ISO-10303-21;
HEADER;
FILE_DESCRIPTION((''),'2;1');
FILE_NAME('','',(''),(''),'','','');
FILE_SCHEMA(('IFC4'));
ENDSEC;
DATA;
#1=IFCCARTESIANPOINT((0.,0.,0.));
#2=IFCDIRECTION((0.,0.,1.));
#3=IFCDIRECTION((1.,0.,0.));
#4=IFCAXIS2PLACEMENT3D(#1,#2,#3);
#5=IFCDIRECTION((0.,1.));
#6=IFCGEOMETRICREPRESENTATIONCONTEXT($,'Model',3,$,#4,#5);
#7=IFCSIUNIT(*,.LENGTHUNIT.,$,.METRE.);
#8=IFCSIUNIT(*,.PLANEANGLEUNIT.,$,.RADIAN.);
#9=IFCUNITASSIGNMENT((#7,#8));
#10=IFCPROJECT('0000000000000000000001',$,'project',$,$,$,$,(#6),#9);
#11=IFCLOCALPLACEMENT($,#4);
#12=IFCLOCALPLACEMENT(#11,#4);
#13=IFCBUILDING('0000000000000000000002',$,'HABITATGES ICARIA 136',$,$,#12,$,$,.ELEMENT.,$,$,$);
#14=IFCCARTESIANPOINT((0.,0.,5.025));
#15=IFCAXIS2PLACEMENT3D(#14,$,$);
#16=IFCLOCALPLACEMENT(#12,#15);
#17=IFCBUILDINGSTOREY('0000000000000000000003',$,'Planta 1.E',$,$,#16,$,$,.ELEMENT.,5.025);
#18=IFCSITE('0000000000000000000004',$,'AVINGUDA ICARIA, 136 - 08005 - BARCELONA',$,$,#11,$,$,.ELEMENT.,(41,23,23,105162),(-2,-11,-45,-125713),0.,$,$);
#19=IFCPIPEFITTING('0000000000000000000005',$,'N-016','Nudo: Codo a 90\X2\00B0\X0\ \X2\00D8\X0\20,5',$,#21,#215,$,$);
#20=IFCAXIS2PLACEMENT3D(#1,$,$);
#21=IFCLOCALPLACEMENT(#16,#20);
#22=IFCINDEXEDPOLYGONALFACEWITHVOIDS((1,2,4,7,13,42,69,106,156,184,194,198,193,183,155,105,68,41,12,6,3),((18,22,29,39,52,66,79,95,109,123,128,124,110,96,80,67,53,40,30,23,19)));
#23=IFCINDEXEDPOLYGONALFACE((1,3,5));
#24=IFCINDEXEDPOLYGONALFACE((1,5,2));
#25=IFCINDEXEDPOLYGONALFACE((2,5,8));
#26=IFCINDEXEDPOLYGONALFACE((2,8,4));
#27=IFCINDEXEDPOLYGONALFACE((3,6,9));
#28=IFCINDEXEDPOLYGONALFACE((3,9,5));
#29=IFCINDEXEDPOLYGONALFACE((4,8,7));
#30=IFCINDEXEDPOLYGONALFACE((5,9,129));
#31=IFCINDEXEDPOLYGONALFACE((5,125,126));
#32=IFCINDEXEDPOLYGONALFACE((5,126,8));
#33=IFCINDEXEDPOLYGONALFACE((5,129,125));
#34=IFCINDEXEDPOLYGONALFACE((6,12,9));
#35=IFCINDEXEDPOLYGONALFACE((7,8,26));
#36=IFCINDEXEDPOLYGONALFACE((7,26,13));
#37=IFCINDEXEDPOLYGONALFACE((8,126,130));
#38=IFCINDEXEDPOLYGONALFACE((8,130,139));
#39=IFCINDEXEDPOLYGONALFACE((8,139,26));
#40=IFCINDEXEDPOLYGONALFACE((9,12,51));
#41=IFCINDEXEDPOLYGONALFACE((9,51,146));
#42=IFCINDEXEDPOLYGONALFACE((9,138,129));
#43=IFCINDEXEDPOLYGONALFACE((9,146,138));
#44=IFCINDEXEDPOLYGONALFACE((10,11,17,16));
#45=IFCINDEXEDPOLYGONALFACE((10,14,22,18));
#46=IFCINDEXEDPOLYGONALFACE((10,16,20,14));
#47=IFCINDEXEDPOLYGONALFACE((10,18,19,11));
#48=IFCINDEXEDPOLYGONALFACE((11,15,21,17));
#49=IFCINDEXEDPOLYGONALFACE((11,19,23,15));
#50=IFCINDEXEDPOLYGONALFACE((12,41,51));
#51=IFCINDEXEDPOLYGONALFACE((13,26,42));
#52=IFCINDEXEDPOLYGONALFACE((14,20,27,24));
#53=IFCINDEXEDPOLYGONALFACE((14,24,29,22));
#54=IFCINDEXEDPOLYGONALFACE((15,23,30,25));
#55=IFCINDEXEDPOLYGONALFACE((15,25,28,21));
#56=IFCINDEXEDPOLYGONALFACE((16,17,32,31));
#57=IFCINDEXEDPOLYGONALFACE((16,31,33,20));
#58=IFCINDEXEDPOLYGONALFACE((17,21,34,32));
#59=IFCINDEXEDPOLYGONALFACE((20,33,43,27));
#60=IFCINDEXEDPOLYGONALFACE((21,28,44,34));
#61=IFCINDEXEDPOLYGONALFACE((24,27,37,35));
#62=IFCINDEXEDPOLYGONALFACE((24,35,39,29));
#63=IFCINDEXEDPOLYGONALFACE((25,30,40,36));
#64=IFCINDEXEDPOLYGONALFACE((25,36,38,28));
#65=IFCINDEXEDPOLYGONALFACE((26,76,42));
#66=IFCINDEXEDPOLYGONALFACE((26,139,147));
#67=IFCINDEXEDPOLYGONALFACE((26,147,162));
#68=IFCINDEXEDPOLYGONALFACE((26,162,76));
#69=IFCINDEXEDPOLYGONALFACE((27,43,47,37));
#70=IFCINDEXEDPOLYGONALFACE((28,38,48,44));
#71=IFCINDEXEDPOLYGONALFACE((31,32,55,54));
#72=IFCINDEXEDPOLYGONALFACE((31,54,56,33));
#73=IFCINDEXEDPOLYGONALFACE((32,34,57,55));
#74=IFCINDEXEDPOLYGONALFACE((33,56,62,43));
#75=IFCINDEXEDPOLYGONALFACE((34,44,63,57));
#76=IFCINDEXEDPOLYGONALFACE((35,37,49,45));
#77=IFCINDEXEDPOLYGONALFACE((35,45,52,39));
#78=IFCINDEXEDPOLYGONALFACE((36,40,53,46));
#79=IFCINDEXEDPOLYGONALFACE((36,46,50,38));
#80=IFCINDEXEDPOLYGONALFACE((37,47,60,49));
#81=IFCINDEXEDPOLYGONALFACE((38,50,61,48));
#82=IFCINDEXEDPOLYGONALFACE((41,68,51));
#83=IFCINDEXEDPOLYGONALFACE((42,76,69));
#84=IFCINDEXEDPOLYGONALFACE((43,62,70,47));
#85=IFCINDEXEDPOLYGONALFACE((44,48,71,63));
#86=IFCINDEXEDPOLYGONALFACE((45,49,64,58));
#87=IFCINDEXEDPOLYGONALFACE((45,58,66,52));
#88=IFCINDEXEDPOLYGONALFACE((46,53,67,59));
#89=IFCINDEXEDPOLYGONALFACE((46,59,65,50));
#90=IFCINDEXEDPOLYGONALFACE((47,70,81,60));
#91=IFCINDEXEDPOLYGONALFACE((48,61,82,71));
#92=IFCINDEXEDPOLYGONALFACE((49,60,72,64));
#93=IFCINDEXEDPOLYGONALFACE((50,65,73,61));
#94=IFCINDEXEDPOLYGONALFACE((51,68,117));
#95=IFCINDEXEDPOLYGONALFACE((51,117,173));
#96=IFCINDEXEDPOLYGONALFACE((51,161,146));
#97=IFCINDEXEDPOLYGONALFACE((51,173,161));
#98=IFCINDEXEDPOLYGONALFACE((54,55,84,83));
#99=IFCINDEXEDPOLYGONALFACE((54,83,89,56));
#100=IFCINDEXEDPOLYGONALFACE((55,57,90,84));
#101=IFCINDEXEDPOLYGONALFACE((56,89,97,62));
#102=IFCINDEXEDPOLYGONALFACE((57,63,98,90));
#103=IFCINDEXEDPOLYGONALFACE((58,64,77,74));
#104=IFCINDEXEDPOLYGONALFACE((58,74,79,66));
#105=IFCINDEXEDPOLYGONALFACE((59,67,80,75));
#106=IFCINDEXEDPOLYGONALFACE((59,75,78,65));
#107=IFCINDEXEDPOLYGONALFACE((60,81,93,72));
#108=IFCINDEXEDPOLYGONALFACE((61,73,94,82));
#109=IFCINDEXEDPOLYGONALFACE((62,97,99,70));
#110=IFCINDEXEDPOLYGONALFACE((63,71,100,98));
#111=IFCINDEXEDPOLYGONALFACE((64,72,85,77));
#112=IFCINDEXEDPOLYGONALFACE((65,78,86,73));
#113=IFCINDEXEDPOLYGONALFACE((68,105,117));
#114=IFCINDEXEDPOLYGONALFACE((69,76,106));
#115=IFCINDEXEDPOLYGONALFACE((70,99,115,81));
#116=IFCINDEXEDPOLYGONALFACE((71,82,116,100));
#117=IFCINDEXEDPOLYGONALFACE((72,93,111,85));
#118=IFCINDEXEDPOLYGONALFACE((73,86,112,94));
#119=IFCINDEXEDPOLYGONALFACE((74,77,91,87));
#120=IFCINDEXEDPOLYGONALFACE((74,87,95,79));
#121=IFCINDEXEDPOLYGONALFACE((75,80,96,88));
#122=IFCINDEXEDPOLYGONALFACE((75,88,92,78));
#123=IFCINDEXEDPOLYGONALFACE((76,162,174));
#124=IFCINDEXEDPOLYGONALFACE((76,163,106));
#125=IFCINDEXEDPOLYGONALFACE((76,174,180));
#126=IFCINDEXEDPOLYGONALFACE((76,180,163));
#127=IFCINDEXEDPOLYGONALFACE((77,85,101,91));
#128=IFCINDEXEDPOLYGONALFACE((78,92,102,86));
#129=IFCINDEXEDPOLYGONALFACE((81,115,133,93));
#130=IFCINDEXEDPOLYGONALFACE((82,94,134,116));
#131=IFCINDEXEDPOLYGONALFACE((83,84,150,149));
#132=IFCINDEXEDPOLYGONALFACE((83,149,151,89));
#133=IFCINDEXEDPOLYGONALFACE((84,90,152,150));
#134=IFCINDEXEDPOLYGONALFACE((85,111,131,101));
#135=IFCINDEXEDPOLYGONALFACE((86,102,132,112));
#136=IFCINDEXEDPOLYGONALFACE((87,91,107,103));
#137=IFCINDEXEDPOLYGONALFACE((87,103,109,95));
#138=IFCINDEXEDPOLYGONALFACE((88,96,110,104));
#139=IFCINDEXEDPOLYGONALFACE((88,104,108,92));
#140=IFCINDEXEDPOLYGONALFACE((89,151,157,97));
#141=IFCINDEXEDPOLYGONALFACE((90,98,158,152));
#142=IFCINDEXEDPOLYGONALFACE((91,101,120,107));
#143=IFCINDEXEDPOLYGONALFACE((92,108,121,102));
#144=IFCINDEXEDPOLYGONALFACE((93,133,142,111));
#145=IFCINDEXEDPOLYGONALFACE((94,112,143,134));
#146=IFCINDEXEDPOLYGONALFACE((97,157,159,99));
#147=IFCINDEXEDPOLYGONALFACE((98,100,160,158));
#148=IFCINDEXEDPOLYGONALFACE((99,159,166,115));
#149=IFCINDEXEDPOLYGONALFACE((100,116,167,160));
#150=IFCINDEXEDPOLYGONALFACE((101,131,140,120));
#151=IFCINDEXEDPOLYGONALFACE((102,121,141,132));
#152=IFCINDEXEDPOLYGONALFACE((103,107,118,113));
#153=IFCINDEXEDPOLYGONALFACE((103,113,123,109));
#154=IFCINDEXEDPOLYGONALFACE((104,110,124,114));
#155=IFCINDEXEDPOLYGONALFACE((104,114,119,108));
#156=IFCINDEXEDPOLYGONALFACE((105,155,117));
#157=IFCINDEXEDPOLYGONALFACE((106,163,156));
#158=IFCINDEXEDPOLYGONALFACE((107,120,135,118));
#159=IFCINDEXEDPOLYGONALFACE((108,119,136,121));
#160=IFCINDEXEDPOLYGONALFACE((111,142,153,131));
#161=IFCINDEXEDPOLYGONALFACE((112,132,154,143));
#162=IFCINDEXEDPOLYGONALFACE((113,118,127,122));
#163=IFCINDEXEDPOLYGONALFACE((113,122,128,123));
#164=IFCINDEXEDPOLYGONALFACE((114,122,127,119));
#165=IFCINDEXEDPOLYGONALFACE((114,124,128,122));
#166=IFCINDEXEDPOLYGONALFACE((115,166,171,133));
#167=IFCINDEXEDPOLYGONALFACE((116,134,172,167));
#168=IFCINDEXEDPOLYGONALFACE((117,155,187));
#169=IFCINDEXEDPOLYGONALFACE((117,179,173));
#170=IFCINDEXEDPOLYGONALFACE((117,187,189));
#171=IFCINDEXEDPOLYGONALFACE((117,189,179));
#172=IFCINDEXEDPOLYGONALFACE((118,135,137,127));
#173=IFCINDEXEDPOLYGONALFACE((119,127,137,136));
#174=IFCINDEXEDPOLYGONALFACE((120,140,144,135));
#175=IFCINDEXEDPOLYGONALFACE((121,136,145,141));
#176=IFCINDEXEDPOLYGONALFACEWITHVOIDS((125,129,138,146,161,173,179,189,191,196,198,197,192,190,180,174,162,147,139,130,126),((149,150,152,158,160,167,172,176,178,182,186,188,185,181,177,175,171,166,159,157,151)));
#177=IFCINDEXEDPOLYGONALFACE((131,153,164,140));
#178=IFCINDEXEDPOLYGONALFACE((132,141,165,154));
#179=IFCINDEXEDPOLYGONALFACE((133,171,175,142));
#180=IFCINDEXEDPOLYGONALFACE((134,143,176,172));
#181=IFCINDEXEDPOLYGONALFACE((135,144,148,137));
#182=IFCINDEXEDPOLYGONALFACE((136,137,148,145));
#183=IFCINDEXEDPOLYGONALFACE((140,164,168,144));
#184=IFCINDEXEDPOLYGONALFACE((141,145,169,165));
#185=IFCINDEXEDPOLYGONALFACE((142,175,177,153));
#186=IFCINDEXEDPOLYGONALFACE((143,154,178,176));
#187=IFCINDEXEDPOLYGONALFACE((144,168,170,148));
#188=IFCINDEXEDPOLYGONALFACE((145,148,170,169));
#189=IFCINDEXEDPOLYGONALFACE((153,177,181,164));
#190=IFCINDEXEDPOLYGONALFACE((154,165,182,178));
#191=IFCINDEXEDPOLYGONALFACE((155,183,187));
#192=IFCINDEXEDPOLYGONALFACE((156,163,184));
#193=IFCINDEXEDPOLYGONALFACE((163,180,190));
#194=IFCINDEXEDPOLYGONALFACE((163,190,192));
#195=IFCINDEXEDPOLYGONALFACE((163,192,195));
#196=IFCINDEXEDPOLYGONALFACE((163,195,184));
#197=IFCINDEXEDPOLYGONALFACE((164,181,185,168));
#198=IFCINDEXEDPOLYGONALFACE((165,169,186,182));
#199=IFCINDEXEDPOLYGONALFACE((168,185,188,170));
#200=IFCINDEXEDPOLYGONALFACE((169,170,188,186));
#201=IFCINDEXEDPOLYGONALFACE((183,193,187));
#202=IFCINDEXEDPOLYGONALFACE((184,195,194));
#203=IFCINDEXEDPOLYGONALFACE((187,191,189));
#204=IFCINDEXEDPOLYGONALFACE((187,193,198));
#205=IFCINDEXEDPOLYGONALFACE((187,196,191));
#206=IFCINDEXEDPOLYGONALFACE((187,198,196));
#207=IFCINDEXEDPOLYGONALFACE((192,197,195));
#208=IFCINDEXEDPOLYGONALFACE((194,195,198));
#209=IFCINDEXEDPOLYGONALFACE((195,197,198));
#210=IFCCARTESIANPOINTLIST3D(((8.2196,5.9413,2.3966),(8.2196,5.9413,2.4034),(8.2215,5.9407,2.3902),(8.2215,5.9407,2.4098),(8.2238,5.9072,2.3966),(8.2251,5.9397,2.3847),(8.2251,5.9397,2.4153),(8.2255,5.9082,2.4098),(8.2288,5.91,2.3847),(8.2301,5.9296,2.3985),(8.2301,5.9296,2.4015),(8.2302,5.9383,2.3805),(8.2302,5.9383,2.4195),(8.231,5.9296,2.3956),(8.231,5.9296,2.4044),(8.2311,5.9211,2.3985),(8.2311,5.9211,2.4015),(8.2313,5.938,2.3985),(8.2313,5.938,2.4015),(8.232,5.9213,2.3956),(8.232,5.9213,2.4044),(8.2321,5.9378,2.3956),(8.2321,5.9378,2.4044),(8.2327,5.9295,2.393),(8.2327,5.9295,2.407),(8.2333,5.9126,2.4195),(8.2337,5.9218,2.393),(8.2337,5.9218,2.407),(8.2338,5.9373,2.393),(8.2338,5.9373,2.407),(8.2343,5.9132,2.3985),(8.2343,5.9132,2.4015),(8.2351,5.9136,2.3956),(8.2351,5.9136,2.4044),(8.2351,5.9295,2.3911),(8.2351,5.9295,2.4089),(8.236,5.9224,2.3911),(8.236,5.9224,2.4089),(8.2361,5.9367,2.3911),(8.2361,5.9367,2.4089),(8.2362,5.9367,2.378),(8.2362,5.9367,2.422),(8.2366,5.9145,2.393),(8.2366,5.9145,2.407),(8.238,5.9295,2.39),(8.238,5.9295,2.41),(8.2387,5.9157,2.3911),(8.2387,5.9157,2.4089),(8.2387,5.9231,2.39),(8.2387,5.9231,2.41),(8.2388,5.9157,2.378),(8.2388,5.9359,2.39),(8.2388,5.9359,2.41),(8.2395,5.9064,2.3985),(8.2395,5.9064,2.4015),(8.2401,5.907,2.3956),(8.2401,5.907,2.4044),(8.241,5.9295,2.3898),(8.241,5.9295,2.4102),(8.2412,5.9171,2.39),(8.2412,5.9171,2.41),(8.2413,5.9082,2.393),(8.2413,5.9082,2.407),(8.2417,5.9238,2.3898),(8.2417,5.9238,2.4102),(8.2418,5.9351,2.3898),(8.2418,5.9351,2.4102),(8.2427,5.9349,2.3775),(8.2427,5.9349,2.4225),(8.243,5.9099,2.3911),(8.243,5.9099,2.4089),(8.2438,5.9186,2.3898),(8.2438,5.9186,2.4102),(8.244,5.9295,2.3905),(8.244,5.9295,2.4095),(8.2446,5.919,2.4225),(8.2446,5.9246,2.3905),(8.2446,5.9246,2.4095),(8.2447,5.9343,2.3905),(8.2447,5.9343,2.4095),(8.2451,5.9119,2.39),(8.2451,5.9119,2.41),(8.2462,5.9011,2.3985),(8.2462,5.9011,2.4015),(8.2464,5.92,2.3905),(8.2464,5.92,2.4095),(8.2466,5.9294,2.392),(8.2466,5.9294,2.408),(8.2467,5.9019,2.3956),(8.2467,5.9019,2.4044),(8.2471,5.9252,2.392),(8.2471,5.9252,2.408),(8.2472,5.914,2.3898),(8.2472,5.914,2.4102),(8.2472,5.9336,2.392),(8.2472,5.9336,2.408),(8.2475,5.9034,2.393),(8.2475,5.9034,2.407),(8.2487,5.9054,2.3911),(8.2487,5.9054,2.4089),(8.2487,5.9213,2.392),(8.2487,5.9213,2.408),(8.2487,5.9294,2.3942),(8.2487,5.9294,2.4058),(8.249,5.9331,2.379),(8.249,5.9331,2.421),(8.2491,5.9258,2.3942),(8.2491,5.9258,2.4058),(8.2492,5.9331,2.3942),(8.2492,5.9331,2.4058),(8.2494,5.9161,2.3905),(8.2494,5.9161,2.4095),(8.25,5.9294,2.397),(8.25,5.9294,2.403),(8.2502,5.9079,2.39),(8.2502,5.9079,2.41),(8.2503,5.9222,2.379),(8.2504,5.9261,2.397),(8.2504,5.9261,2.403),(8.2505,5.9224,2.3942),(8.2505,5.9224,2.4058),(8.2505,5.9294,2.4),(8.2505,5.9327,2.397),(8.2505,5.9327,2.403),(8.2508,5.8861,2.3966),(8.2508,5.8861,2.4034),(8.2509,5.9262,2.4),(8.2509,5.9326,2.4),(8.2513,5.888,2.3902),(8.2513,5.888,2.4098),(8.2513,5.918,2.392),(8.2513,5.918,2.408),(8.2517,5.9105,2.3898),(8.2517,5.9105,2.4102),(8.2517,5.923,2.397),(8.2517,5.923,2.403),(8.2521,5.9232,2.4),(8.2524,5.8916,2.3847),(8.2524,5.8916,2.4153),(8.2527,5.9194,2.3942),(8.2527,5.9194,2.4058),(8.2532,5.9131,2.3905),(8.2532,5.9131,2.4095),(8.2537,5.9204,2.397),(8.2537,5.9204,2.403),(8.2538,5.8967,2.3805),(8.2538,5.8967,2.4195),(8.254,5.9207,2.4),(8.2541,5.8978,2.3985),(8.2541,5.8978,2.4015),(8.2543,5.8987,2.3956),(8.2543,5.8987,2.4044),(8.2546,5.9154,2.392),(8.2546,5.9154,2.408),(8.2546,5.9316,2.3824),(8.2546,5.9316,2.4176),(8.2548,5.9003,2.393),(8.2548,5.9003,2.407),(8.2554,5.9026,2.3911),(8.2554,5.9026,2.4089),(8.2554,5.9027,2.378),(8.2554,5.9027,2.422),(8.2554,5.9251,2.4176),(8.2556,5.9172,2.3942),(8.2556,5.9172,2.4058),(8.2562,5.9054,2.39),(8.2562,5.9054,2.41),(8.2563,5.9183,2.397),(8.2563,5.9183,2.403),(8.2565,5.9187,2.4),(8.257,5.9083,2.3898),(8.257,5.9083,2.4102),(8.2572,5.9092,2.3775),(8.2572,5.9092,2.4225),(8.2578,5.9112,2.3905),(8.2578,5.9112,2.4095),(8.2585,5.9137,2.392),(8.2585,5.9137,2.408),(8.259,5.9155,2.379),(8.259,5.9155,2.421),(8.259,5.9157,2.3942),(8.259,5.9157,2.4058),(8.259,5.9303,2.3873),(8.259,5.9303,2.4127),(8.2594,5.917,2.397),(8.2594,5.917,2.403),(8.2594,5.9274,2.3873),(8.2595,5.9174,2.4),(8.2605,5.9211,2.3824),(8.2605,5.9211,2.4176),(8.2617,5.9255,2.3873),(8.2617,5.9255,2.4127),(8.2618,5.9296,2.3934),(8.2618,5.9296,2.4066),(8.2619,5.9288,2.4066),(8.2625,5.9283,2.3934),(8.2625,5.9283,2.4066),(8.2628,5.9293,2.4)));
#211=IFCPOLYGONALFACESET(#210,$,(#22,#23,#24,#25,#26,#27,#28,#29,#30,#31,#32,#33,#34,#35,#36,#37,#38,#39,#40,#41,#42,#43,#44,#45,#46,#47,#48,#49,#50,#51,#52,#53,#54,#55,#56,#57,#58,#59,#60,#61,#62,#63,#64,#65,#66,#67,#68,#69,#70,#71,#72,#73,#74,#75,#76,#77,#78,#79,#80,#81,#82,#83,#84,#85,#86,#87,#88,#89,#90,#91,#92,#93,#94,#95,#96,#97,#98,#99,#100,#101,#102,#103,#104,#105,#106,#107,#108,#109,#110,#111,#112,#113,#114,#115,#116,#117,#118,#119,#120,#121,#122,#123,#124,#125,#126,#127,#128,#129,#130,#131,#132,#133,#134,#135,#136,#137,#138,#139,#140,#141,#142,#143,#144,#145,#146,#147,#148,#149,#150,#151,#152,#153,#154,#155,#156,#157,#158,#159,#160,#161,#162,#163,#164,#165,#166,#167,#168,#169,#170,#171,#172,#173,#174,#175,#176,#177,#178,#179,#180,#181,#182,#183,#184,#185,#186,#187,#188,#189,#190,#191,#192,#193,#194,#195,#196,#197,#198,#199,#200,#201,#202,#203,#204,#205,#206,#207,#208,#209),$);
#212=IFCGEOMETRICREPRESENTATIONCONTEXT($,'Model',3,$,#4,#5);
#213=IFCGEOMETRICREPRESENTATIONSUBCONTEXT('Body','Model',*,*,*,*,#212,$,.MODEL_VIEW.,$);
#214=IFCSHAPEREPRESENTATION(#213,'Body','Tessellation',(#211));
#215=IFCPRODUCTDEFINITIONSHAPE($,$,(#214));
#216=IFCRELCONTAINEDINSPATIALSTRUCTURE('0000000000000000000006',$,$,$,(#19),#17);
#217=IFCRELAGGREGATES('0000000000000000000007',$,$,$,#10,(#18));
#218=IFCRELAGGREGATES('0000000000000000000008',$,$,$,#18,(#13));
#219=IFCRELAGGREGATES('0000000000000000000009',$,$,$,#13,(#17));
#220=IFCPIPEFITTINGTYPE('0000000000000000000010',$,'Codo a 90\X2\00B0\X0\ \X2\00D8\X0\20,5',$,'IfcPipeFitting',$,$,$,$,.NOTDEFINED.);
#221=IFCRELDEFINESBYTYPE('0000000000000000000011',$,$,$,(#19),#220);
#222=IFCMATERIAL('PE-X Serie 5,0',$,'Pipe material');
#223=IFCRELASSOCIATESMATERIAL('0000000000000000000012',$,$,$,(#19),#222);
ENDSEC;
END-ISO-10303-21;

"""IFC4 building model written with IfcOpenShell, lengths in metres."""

from ifc_helpers import new_model, entity, si_unit, direction, frame, origin_with_axes, place, context, subcontext, project, spatial, source, transform, mapped, material, type_object, element, save


model = new_model("IFC4")

# Units and contexts
model_context_1 = context("Model", 3, world=origin_with_axes(), true_north=direction((0.0, 1.0)))
model_context_2 = context("Model", 3, world=origin_with_axes(), true_north=direction((0.0, 1.0)))
body_context_1 = subcontext(model_context_2, "Body", "Model", "MODEL_VIEW")
ifc_project = project(units=[si_unit("LENGTHUNIT", "METRE"), si_unit("PLANEANGLEUNIT", "RADIAN")], contexts=[model_context_1])

# Site, building, storey
site_placement = place(None, origin_with_axes())
site = spatial("IfcSite", under=ifc_project, at=site_placement, Name="AVINGUDA ICARIA, 136 - 08005 - BARCELONA", CompositionType="ELEMENT", RefLatitude=(41, 23, 23, 105162), RefLongitude=(-2, -11, -45, -125713), RefElevation=0.0)
building_placement = place(site_placement, origin_with_axes())
building = spatial("IfcBuilding", under=site, at=building_placement, Name="HABITATGES ICARIA 136", CompositionType="ELEMENT")
storey_placement = place(building_placement, frame((0.0, 0.0, 5.025)))
storey = spatial("IfcBuildingStorey", under=building, at=storey_placement, Name="Planta 1.E", CompositionType="ELEMENT", Elevation=5.025)

# Shared definitions
ifc_material_1 = material(Name="PE-X Serie 5,0", Category="Pipe material")
placement_1 = place(None, origin_with_axes())
placement_2 = place(placement_1, origin_with_axes())
placement_3 = place(placement_2, frame((0.0, 0.0, 5.025)))

# Pipe fitting
pipe_fitting_type_1 = type_object("IfcPipeFittingType", Name="Codo a 90° Ø20,5", ApplicableOccurrence="IfcPipeFitting", PredefinedType="NOTDEFINED")
shared_shape_1 = source(origin_with_axes(), body_context_1, "Body", "SweptSolid", [
    entity("IfcRevolvedAreaSolid", entity("IfcCircleHollowProfileDef", "AREA", None, entity("IfcAxis2Placement2D", entity("IfcCartesianPoint", [0.0, 0.0]), entity("IfcDirection", [1.0, 0.0])), 0.0226, 0.0123), entity("IfcAxis2Placement3D", entity("IfcCartesianPoint", [0.0226, 0.0, 0.0]), entity("IfcDirection", [-1.0, 0.0, 0.0]), entity("IfcDirection", [0.0, -1.0, 0.0])), entity("IfcAxis1Placement", entity("IfcCartesianPoint", [0.0226, 0.0, 0.0]), entity("IfcDirection", [0.0, 1.0, 0.0])), 1.570796),
])
pipe_fitting_1_placement = place(placement_3, origin_with_axes())
element("IfcPipeFitting", 1, at=pipe_fitting_1_placement, inside=storey, type_object=pipe_fitting_type_1, material=ifc_material_1, Name="N-016", Description="Nudo: Codo a 90° Ø20,5", context=body_context_1, shape_type="MappedRepresentation", body=[
    mapped(shared_shape_1, transform((8.235, 5.9136, 2.4), x_axis=(0.96374, -0.266843, 0.0), y_axis=(-0.266843, -0.96374, 0.0), z_axis=(0.0, 0.0, -1.0), scale=1.0)),
])

save(model, "model.ifc")
